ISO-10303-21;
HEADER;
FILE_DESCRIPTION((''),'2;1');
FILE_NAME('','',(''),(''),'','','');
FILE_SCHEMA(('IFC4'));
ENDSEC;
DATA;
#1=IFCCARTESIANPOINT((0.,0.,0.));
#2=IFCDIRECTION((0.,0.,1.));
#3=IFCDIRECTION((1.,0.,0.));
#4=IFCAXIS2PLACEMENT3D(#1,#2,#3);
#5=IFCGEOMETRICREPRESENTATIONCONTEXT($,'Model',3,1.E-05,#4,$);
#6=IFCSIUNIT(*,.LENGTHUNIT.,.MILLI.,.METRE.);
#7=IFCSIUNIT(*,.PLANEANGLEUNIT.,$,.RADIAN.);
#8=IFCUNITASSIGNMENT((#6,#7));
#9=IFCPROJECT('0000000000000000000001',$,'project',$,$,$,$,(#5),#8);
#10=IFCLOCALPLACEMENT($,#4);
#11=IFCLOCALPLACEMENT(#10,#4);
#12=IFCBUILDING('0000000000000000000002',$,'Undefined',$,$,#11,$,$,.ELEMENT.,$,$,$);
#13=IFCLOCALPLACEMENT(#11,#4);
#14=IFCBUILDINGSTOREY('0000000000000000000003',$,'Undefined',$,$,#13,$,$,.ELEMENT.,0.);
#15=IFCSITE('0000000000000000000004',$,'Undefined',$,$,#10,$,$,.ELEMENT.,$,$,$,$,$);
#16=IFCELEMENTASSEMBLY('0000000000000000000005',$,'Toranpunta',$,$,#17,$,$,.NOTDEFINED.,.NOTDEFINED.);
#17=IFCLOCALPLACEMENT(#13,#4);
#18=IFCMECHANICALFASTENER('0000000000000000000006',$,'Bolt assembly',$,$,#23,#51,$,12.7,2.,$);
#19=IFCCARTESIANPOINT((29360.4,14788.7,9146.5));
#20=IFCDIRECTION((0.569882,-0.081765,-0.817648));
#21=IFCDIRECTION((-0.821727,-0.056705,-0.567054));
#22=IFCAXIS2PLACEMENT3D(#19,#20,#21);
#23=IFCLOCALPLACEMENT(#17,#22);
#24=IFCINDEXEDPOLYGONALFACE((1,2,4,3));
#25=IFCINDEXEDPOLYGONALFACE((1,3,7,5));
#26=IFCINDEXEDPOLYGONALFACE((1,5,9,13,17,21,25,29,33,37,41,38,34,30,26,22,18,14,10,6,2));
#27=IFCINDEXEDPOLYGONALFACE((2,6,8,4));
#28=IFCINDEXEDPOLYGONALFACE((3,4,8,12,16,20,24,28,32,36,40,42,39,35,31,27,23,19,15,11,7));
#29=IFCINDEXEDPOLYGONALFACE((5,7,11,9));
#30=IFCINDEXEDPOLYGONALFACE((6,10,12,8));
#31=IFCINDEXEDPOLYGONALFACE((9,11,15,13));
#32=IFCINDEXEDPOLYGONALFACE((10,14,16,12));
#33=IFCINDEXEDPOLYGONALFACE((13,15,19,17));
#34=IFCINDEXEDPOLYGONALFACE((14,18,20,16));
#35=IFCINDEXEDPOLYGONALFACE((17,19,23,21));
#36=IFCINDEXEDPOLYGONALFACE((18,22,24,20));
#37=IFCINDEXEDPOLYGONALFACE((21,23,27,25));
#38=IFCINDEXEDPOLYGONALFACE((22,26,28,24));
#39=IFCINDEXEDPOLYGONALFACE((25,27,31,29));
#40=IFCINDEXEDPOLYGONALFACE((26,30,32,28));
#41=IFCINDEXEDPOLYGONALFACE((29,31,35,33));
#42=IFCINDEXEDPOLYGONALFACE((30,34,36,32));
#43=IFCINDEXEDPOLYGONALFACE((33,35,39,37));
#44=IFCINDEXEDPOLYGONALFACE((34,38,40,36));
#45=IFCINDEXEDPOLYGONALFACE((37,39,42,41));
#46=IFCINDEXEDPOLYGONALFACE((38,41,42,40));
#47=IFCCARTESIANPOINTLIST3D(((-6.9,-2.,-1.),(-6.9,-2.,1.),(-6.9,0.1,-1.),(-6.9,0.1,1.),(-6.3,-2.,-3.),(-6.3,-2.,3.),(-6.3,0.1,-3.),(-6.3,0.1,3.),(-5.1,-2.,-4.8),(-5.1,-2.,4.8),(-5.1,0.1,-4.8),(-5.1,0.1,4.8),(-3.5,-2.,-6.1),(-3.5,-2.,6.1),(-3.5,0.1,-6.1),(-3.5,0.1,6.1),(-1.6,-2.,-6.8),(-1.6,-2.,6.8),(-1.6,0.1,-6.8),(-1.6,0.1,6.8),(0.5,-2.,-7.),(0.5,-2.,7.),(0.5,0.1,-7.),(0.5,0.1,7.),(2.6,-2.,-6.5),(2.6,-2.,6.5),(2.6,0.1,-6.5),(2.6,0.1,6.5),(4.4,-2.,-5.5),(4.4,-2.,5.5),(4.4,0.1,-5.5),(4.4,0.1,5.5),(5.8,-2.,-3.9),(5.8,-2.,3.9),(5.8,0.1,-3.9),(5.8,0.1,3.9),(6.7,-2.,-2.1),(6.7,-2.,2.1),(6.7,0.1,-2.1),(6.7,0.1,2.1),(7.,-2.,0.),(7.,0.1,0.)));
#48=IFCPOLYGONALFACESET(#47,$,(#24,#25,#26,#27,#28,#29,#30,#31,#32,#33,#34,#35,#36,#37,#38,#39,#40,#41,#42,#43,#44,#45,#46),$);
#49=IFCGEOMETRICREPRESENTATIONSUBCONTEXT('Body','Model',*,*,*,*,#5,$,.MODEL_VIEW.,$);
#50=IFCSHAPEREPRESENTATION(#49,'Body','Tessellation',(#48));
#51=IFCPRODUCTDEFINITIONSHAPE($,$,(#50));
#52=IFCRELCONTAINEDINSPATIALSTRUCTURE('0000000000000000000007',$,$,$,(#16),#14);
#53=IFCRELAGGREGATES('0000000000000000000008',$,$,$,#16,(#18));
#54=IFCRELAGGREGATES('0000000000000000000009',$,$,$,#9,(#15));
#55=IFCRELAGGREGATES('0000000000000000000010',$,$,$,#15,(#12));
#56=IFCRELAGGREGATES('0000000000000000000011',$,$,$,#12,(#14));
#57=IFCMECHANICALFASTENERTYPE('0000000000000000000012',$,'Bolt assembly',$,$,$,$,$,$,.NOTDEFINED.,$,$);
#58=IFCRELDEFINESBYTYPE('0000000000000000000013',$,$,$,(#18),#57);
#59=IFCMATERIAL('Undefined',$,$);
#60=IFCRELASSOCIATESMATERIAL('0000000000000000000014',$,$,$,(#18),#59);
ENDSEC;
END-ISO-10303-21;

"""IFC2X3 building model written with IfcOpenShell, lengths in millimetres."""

from ifc_helpers import new_model, si_unit, frame, origin_with_axes, origin_2d_with_axis, place, context, subcontext, project, spatial, circle, extrude, source, transform, mapped, material, type_object, element, aggregate, save


model = new_model("IFC2X3")

# Units and contexts
model_context = context("Model", 3, precision=1e-05, world=origin_with_axes())
body_context = subcontext(model_context, "Body", "Model", "MODEL_VIEW")
ifc_project = project(units=[si_unit("LENGTHUNIT", "METRE", prefix="MILLI"), si_unit("PLANEANGLEUNIT", "RADIAN")], contexts=[model_context])

# Site, building, storey
site_placement = place(None, origin_with_axes())
site = spatial("IfcSite", under=ifc_project, at=site_placement, Name="Undefined", CompositionType="ELEMENT")
building_placement = place(site_placement, origin_with_axes())
building = spatial("IfcBuilding", under=site, at=building_placement, Name="Undefined", CompositionType="ELEMENT")
storey_placement = place(building_placement, origin_with_axes())
storey = spatial("IfcBuildingStorey", under=building, at=storey_placement, Name="Undefined", CompositionType="ELEMENT", Elevation=0.0)

# Element assembly, mechanical fastener
assembly_1_placement = place(storey_placement, origin_with_axes())
assembly_1 = element("IfcElementAssembly", 1, at=assembly_1_placement, inside=storey, Name="Toranpunta", AssemblyPlace="NOTDEFINED", PredefinedType="NOTDEFINED")
ifc_material_1 = material(Name="Undefined")
mechanical_fastener_type = type_object("IfcMechanicalFastenerType", Name="Bolt assembly")
shared_shape_1 = source(origin_with_axes(), body_context, "Body", "SweptSolid", [
    extrude(circle(Radius=7.0, at=origin_2d_with_axis()), frame((0.0, -2.0, 0.0), z_axis=(0.0, 1.0, 0.0), x_axis=(1.0, 0.0, 0.0)), (0.0, 0.0, 1.0), 2.1),
])
mechanical_fastener_1_placement = place(assembly_1_placement, frame((29360.4, 14788.7, 9146.5), z_axis=(0.569882, -0.081765, -0.817648), x_axis=(-0.821727, -0.056705, -0.567054)))
mechanical_fastener_1 = element("IfcMechanicalFastener", 2, at=mechanical_fastener_1_placement, type_object=mechanical_fastener_type, material=ifc_material_1, Name="Bolt assembly", NominalDiameter=12.7, NominalLength=2.0, context=body_context, shape_type="MappedRepresentation", body=[
    mapped(shared_shape_1, transform((0.0, 0.0, 0.0))),
])
aggregate(assembly_1, [mechanical_fastener_1])

save(model, "model.ifc")
